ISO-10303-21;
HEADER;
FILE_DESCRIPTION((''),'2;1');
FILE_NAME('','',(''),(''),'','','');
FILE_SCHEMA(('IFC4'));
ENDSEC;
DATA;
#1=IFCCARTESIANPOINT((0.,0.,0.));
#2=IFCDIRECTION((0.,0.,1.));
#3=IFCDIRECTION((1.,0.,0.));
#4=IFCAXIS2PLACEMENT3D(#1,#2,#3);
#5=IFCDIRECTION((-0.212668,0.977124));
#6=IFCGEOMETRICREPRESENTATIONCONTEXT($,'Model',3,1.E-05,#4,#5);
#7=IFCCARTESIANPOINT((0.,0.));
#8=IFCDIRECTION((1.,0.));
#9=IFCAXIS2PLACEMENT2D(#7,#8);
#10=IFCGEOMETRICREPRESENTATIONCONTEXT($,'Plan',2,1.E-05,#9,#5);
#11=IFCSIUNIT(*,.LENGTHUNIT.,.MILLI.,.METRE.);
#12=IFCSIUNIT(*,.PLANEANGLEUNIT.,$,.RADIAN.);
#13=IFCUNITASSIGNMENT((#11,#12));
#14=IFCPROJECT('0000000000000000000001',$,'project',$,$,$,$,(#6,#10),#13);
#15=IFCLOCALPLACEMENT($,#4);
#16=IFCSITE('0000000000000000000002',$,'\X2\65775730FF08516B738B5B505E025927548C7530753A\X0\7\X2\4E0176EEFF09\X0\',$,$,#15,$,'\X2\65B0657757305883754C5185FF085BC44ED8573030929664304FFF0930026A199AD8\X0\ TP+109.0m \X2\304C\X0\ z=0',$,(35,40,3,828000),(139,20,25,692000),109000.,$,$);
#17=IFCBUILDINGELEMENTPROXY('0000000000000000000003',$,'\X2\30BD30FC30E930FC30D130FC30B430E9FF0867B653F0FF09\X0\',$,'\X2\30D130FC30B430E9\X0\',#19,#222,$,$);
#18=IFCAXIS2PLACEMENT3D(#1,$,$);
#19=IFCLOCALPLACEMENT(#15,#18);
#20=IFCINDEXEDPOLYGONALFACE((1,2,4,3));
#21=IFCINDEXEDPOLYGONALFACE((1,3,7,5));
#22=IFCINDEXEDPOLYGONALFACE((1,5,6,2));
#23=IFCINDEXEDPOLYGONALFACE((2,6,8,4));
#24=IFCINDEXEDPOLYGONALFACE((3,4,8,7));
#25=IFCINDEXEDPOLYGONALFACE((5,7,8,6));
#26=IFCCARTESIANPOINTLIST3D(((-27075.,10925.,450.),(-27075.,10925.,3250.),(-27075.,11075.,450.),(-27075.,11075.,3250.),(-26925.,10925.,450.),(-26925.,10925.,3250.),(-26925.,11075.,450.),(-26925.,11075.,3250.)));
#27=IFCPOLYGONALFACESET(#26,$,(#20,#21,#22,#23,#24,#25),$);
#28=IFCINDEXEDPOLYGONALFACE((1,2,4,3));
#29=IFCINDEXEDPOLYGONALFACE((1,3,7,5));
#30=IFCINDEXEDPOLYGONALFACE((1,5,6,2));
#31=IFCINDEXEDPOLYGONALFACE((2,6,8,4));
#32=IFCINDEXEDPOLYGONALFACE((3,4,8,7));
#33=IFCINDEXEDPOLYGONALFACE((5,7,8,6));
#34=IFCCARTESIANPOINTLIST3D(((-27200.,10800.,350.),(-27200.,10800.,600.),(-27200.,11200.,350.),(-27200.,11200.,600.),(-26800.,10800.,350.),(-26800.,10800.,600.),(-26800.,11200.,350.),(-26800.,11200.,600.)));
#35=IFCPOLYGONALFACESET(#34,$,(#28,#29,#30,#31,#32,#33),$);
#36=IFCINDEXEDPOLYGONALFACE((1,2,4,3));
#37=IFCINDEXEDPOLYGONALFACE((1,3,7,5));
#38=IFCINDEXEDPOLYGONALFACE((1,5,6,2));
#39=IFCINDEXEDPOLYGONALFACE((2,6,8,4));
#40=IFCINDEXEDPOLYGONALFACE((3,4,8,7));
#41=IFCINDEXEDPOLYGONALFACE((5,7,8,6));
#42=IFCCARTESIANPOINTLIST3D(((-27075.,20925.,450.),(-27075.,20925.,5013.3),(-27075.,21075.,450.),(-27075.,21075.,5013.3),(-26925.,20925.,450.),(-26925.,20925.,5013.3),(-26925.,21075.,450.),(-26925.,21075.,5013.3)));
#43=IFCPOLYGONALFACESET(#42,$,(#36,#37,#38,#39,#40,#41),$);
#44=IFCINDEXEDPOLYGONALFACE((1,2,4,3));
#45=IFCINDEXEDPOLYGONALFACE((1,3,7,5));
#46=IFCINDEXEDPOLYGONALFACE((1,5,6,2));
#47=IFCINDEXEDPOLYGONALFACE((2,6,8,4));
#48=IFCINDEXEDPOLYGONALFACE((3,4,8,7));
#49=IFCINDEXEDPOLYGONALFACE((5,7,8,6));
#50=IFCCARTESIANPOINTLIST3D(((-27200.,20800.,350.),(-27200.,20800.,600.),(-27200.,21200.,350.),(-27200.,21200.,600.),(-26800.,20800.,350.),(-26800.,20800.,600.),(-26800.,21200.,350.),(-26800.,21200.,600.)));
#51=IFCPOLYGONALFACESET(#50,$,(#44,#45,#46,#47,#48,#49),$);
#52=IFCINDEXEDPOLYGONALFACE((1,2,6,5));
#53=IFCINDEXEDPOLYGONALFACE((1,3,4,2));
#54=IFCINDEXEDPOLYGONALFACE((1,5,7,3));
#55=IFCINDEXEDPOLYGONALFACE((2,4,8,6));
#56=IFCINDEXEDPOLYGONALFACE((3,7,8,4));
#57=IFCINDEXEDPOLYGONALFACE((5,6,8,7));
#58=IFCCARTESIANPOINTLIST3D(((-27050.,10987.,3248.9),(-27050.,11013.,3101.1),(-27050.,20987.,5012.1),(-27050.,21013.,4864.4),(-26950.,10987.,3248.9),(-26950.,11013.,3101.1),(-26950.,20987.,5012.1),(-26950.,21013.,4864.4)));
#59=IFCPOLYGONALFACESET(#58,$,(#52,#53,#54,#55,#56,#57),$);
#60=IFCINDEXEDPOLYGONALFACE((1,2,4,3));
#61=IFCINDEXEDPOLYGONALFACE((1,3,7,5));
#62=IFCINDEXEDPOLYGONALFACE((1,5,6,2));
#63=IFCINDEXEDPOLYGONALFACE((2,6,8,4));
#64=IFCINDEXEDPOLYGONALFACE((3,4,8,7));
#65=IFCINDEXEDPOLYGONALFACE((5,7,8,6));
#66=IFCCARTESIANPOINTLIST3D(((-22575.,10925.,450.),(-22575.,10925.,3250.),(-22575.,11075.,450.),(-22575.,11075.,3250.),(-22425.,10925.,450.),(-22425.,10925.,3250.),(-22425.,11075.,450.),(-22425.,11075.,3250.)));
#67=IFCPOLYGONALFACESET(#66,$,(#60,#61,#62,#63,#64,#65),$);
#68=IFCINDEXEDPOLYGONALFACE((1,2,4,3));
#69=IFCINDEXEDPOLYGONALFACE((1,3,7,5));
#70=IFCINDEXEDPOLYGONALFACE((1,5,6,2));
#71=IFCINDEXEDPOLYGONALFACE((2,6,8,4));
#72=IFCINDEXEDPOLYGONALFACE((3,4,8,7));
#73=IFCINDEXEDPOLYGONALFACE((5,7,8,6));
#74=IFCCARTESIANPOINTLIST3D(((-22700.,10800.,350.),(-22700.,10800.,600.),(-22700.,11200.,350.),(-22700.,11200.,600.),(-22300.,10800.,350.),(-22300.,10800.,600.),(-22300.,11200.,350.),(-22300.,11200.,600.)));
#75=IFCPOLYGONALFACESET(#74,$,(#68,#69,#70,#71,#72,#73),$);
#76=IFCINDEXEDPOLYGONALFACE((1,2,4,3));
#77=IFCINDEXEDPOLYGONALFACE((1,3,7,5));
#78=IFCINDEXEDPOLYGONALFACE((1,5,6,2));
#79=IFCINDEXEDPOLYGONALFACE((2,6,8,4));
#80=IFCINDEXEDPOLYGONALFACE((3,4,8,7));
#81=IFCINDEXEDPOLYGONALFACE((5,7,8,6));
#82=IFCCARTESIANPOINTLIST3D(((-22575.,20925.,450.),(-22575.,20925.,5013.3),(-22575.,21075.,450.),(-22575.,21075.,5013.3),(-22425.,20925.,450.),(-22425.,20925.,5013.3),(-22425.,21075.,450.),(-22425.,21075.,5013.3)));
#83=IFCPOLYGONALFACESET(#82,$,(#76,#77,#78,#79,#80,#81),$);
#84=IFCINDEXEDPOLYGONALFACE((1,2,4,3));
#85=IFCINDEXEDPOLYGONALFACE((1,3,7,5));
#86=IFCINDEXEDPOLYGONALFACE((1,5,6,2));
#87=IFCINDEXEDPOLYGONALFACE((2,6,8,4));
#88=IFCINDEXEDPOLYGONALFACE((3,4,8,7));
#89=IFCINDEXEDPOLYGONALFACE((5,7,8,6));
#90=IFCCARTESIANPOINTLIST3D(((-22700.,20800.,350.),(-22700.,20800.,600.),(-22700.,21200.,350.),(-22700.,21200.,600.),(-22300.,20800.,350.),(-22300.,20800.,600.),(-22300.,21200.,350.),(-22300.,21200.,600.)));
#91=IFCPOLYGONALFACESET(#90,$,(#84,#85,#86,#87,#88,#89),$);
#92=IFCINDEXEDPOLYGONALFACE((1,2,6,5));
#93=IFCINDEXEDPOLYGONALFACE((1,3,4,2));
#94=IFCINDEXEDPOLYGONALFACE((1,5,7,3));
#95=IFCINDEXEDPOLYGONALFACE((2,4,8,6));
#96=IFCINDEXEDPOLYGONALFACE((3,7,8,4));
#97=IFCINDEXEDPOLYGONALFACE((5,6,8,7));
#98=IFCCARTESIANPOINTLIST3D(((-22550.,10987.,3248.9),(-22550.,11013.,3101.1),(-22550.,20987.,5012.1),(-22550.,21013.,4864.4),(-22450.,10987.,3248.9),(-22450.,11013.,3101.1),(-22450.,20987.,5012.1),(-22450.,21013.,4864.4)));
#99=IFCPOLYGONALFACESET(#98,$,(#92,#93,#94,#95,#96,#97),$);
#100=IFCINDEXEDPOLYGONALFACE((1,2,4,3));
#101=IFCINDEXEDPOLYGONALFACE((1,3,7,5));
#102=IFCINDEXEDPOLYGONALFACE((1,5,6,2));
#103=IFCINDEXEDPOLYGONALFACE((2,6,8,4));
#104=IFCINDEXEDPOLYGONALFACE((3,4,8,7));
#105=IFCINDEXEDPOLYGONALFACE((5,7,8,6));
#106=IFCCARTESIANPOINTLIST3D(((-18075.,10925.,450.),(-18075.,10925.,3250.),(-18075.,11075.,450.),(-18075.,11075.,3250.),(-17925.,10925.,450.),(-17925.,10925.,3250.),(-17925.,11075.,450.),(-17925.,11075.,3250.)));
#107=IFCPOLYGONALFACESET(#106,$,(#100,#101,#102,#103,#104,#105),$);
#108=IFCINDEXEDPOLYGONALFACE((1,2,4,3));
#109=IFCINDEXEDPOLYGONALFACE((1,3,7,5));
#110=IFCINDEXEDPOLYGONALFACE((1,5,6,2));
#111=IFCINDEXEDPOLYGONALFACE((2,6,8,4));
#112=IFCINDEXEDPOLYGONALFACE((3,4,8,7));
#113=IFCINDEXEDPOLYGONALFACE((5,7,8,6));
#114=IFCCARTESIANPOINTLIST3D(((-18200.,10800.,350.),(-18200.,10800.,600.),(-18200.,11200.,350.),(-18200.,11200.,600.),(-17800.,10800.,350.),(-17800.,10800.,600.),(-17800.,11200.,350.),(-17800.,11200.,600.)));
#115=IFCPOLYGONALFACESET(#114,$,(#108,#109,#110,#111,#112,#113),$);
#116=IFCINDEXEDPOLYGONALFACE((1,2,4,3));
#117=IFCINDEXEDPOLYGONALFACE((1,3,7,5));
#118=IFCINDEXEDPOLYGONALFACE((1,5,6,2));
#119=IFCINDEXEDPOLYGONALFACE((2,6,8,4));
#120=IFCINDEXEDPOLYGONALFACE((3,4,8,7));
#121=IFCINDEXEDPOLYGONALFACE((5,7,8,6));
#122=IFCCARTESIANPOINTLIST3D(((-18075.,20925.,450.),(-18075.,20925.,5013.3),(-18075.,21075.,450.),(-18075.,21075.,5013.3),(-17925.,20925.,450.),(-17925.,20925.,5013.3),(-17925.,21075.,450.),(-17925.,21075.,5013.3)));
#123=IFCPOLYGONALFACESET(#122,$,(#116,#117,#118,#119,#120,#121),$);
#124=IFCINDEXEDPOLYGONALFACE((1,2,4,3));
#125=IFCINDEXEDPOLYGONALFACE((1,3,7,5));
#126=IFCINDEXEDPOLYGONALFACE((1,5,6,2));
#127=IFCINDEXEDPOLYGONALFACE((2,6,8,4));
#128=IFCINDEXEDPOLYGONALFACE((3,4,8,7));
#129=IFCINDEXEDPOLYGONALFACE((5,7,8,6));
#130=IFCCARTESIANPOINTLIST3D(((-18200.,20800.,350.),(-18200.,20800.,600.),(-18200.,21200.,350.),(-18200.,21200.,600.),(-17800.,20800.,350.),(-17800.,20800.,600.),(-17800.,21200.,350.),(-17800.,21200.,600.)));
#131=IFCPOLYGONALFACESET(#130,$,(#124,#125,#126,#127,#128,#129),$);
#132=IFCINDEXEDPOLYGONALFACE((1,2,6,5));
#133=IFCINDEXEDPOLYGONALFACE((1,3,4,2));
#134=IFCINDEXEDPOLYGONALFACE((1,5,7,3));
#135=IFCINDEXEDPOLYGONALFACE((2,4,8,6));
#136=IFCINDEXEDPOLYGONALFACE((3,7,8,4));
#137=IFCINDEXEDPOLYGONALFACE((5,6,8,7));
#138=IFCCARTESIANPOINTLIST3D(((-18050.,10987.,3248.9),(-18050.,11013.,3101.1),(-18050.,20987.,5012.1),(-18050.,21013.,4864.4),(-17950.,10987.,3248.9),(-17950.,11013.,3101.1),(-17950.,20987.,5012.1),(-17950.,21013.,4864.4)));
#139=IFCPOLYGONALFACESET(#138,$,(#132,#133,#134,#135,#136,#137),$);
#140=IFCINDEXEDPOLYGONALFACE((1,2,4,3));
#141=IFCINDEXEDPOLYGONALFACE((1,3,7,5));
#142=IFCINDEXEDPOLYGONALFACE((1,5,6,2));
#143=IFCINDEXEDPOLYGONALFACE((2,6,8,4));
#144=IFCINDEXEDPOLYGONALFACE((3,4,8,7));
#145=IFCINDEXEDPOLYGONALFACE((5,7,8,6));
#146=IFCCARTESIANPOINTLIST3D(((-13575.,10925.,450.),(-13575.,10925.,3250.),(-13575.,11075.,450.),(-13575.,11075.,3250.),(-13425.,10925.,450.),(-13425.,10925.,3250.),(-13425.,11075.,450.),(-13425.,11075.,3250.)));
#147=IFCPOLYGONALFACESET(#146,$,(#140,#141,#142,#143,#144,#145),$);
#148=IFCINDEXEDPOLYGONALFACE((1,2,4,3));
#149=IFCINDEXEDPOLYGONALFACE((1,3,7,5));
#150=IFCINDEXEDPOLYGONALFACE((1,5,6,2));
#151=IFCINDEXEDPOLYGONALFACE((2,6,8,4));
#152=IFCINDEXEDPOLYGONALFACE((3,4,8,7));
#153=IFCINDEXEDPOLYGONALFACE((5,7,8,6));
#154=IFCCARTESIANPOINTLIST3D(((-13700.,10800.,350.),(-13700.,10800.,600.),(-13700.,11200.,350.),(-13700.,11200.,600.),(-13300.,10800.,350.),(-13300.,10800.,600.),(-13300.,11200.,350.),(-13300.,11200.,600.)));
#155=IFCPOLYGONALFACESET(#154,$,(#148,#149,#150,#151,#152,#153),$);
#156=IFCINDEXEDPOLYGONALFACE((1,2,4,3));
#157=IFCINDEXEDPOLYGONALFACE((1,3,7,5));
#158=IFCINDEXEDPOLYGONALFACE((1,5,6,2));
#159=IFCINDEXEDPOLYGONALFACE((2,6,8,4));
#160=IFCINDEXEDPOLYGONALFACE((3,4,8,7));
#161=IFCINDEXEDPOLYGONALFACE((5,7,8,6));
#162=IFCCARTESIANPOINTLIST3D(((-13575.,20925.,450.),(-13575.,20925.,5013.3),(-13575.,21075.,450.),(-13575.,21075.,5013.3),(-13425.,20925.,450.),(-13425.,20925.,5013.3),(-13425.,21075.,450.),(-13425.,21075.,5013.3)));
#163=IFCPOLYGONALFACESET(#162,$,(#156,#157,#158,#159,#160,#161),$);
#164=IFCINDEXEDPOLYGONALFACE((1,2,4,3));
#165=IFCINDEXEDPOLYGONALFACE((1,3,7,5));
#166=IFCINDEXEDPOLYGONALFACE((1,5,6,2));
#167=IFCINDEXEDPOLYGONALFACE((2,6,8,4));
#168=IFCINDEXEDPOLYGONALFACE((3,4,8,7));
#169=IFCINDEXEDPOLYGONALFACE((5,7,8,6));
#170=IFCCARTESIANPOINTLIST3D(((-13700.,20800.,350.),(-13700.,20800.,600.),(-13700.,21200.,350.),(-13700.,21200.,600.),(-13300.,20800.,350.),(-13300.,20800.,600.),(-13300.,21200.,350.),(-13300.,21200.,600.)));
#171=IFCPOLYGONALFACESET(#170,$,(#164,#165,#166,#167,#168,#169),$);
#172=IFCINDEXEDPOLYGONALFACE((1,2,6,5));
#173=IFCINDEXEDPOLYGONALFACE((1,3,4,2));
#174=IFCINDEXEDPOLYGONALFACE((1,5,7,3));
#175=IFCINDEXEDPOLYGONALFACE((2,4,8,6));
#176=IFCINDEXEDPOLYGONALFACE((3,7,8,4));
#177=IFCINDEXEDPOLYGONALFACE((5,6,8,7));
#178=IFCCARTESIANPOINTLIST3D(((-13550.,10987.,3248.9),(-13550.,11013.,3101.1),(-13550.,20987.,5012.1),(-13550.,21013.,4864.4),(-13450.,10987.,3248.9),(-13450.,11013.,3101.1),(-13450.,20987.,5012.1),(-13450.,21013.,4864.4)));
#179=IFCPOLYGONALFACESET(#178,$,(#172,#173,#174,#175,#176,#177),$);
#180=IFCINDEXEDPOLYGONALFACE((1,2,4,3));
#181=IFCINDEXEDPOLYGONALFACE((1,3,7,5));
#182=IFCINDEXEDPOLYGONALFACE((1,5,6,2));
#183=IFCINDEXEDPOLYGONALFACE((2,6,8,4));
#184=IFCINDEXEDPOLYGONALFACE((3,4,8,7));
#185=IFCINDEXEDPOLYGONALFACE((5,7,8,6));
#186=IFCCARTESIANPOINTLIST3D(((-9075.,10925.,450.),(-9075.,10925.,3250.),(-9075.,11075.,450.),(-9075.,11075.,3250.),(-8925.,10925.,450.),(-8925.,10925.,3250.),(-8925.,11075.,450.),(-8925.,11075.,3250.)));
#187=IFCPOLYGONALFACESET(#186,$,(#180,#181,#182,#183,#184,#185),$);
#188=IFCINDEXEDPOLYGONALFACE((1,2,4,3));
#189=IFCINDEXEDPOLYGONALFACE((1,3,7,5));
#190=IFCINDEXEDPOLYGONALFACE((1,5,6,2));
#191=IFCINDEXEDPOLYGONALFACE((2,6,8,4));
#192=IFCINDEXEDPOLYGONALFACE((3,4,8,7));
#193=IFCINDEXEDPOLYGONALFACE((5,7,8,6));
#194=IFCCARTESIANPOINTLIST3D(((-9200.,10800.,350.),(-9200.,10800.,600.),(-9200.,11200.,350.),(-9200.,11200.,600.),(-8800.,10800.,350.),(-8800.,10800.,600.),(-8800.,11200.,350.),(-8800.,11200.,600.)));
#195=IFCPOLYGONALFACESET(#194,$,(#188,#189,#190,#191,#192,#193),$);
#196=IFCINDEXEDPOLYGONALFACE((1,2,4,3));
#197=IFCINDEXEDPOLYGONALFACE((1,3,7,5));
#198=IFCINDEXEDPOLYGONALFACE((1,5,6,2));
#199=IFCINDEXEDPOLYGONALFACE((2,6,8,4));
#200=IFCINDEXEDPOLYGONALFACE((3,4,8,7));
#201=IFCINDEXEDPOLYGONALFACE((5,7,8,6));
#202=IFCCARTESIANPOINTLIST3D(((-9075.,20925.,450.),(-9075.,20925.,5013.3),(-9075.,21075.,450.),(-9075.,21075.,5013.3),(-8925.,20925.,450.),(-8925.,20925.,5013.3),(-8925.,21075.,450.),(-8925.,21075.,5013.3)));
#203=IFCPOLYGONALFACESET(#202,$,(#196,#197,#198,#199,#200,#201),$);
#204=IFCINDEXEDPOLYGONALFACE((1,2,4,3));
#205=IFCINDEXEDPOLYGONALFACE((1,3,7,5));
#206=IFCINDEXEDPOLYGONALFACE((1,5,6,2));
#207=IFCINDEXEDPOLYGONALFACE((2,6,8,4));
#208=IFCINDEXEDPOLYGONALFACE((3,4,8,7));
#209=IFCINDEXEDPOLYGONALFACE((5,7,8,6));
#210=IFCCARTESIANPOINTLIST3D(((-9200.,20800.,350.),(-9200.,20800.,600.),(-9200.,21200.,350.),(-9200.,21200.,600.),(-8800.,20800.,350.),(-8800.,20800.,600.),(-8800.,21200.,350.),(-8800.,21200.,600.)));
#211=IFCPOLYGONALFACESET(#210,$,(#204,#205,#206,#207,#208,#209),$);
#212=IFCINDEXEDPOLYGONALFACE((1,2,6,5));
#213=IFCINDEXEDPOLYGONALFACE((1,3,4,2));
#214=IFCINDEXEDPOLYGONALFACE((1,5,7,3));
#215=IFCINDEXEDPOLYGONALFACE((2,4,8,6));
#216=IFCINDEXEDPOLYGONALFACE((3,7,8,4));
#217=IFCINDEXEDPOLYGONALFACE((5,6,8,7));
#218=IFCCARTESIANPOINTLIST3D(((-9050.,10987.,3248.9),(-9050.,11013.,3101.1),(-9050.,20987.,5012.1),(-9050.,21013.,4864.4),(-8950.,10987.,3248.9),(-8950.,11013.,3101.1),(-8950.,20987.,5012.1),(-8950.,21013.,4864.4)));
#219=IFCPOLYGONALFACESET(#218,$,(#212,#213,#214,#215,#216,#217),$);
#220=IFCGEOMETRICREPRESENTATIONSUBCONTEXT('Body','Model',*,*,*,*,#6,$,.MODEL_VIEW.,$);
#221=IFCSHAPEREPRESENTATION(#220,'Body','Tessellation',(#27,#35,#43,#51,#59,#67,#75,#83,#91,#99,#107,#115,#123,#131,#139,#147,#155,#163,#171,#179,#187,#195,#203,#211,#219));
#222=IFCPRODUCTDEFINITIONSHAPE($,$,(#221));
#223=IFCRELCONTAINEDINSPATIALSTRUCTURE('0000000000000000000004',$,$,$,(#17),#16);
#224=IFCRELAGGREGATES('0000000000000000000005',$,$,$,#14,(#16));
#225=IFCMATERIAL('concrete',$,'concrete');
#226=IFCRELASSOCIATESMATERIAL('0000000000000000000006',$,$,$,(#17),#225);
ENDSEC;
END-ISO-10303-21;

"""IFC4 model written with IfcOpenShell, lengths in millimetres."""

from ifc_helpers import new_model, si_unit, direction, frame, frame_2d, origin_with_axes, origin_2d, origin_2d_with_axis, place, context, subcontext, project, spatial, rectangle, extrude, material, element, save


model = new_model("IFC4")

# Units and contexts
model_context = context("Model", 3, precision=1e-05, world=origin_with_axes(), true_north=direction((-0.212668, 0.977124)))
plan_context = context("Plan", 2, precision=1e-05, world=origin_2d_with_axis(), true_north=direction((-0.212668, 0.977124)))
body_context = subcontext(model_context, "Body", "Model", "MODEL_VIEW")
ifc_project = project(units=[si_unit("LENGTHUNIT", "METRE", prefix="MILLI"), si_unit("PLANEANGLEUNIT", "RADIAN")], contexts=[model_context, plan_context])

# Site
site_placement = place(None, origin_with_axes())
site = spatial("IfcSite", under=ifc_project, at=site_placement, Name="敷地（八王子市大和田町7丁目）", LongName="新敷地境界内（寄付地を除く）。標高 TP+109.0m が z=0", RefLatitude=(35, 40, 3, 828000), RefLongitude=(139, 20, 25, 692000), RefElevation=109000.0)

# Shared definitions
ifc_material_1 = material(Name="concrete", Category="concrete")

# Building element proxy
proxy_1_placement = place(site_placement, origin_with_axes())
element("IfcBuildingElementProxy", 1, at=proxy_1_placement, inside=site, material=ifc_material_1, Name="ソーラーパーゴラ（架台）", ObjectType="パーゴラ", context=body_context, shape_type="SweptSolid", body=[
    extrude(rectangle(XDim=150.0, YDim=150.0, at=frame_2d((-27000.0, 11000.0))), frame((0.0, 0.0, 450.0)), (0.0, 0.0, 1.0), 2800.0),
    extrude(rectangle(XDim=400.0, YDim=400.0, at=frame_2d((-27000.0, 11000.0))), frame((0.0, 0.0, 350.0)), (0.0, 0.0, 1.0), 250.0),
    extrude(rectangle(XDim=150.0, YDim=150.0, at=frame_2d((-27000.0, 21000.0))), frame((0.0, 0.0, 450.0)), (0.0, 0.0, 1.0), 4563.3),
    extrude(rectangle(XDim=400.0, YDim=400.0, at=frame_2d((-27000.0, 21000.0))), frame((0.0, 0.0, 350.0)), (0.0, 0.0, 1.0), 250.0),
    extrude(rectangle(XDim=100.0, YDim=10154.3, at=origin_2d()), frame((-27000.0, 16013.0, 3982.8), z_axis=(0.0, -0.173648, 0.984808), x_axis=(1.0, 0.0, 0.0)), (0.0, 0.0, 1.0), 150.0),
    extrude(rectangle(XDim=150.0, YDim=150.0, at=frame_2d((-22500.0, 11000.0))), frame((0.0, 0.0, 450.0)), (0.0, 0.0, 1.0), 2800.0),
    extrude(rectangle(XDim=400.0, YDim=400.0, at=frame_2d((-22500.0, 11000.0))), frame((0.0, 0.0, 350.0)), (0.0, 0.0, 1.0), 250.0),
    extrude(rectangle(XDim=150.0, YDim=150.0, at=frame_2d((-22500.0, 21000.0))), frame((0.0, 0.0, 450.0)), (0.0, 0.0, 1.0), 4563.3),
    extrude(rectangle(XDim=400.0, YDim=400.0, at=frame_2d((-22500.0, 21000.0))), frame((0.0, 0.0, 350.0)), (0.0, 0.0, 1.0), 250.0),
    extrude(rectangle(XDim=100.0, YDim=10154.3, at=origin_2d()), frame((-22500.0, 16013.0, 3982.8), z_axis=(0.0, -0.173648, 0.984808), x_axis=(1.0, 0.0, 0.0)), (0.0, 0.0, 1.0), 150.0),
    extrude(rectangle(XDim=150.0, YDim=150.0, at=frame_2d((-18000.0, 11000.0))), frame((0.0, 0.0, 450.0)), (0.0, 0.0, 1.0), 2800.0),
    extrude(rectangle(XDim=400.0, YDim=400.0, at=frame_2d((-18000.0, 11000.0))), frame((0.0, 0.0, 350.0)), (0.0, 0.0, 1.0), 250.0),
    extrude(rectangle(XDim=150.0, YDim=150.0, at=frame_2d((-18000.0, 21000.0))), frame((0.0, 0.0, 450.0)), (0.0, 0.0, 1.0), 4563.3),
    extrude(rectangle(XDim=400.0, YDim=400.0, at=frame_2d((-18000.0, 21000.0))), frame((0.0, 0.0, 350.0)), (0.0, 0.0, 1.0), 250.0),
    extrude(rectangle(XDim=100.0, YDim=10154.3, at=origin_2d()), frame((-18000.0, 16013.0, 3982.8), z_axis=(0.0, -0.173648, 0.984808), x_axis=(1.0, 0.0, 0.0)), (0.0, 0.0, 1.0), 150.0),
    extrude(rectangle(XDim=150.0, YDim=150.0, at=frame_2d((-13500.0, 11000.0))), frame((0.0, 0.0, 450.0)), (0.0, 0.0, 1.0), 2800.0),
    extrude(rectangle(XDim=400.0, YDim=400.0, at=frame_2d((-13500.0, 11000.0))), frame((0.0, 0.0, 350.0)), (0.0, 0.0, 1.0), 250.0),
    extrude(rectangle(XDim=150.0, YDim=150.0, at=frame_2d((-13500.0, 21000.0))), frame((0.0, 0.0, 450.0)), (0.0, 0.0, 1.0), 4563.3),
    extrude(rectangle(XDim=400.0, YDim=400.0, at=frame_2d((-13500.0, 21000.0))), frame((0.0, 0.0, 350.0)), (0.0, 0.0, 1.0), 250.0),
    extrude(rectangle(XDim=100.0, YDim=10154.3, at=origin_2d()), frame((-13500.0, 16013.0, 3982.8), z_axis=(0.0, -0.173648, 0.984808), x_axis=(1.0, 0.0, 0.0)), (0.0, 0.0, 1.0), 150.0),
    extrude(rectangle(XDim=150.0, YDim=150.0, at=frame_2d((-9000.0, 11000.0))), frame((0.0, 0.0, 450.0)), (0.0, 0.0, 1.0), 2800.0),
    extrude(rectangle(XDim=400.0, YDim=400.0, at=frame_2d((-9000.0, 11000.0))), frame((0.0, 0.0, 350.0)), (0.0, 0.0, 1.0), 250.0),
    extrude(rectangle(XDim=150.0, YDim=150.0, at=frame_2d((-9000.0, 21000.0))), frame((0.0, 0.0, 450.0)), (0.0, 0.0, 1.0), 4563.3),
    extrude(rectangle(XDim=400.0, YDim=400.0, at=frame_2d((-9000.0, 21000.0))), frame((0.0, 0.0, 350.0)), (0.0, 0.0, 1.0), 250.0),
    extrude(rectangle(XDim=100.0, YDim=10154.3, at=origin_2d()), frame((-9000.0, 16013.0, 3982.8), z_axis=(0.0, -0.173648, 0.984808), x_axis=(1.0, 0.0, 0.0)), (0.0, 0.0, 1.0), 150.0),
])

save(model, "model.ifc")
